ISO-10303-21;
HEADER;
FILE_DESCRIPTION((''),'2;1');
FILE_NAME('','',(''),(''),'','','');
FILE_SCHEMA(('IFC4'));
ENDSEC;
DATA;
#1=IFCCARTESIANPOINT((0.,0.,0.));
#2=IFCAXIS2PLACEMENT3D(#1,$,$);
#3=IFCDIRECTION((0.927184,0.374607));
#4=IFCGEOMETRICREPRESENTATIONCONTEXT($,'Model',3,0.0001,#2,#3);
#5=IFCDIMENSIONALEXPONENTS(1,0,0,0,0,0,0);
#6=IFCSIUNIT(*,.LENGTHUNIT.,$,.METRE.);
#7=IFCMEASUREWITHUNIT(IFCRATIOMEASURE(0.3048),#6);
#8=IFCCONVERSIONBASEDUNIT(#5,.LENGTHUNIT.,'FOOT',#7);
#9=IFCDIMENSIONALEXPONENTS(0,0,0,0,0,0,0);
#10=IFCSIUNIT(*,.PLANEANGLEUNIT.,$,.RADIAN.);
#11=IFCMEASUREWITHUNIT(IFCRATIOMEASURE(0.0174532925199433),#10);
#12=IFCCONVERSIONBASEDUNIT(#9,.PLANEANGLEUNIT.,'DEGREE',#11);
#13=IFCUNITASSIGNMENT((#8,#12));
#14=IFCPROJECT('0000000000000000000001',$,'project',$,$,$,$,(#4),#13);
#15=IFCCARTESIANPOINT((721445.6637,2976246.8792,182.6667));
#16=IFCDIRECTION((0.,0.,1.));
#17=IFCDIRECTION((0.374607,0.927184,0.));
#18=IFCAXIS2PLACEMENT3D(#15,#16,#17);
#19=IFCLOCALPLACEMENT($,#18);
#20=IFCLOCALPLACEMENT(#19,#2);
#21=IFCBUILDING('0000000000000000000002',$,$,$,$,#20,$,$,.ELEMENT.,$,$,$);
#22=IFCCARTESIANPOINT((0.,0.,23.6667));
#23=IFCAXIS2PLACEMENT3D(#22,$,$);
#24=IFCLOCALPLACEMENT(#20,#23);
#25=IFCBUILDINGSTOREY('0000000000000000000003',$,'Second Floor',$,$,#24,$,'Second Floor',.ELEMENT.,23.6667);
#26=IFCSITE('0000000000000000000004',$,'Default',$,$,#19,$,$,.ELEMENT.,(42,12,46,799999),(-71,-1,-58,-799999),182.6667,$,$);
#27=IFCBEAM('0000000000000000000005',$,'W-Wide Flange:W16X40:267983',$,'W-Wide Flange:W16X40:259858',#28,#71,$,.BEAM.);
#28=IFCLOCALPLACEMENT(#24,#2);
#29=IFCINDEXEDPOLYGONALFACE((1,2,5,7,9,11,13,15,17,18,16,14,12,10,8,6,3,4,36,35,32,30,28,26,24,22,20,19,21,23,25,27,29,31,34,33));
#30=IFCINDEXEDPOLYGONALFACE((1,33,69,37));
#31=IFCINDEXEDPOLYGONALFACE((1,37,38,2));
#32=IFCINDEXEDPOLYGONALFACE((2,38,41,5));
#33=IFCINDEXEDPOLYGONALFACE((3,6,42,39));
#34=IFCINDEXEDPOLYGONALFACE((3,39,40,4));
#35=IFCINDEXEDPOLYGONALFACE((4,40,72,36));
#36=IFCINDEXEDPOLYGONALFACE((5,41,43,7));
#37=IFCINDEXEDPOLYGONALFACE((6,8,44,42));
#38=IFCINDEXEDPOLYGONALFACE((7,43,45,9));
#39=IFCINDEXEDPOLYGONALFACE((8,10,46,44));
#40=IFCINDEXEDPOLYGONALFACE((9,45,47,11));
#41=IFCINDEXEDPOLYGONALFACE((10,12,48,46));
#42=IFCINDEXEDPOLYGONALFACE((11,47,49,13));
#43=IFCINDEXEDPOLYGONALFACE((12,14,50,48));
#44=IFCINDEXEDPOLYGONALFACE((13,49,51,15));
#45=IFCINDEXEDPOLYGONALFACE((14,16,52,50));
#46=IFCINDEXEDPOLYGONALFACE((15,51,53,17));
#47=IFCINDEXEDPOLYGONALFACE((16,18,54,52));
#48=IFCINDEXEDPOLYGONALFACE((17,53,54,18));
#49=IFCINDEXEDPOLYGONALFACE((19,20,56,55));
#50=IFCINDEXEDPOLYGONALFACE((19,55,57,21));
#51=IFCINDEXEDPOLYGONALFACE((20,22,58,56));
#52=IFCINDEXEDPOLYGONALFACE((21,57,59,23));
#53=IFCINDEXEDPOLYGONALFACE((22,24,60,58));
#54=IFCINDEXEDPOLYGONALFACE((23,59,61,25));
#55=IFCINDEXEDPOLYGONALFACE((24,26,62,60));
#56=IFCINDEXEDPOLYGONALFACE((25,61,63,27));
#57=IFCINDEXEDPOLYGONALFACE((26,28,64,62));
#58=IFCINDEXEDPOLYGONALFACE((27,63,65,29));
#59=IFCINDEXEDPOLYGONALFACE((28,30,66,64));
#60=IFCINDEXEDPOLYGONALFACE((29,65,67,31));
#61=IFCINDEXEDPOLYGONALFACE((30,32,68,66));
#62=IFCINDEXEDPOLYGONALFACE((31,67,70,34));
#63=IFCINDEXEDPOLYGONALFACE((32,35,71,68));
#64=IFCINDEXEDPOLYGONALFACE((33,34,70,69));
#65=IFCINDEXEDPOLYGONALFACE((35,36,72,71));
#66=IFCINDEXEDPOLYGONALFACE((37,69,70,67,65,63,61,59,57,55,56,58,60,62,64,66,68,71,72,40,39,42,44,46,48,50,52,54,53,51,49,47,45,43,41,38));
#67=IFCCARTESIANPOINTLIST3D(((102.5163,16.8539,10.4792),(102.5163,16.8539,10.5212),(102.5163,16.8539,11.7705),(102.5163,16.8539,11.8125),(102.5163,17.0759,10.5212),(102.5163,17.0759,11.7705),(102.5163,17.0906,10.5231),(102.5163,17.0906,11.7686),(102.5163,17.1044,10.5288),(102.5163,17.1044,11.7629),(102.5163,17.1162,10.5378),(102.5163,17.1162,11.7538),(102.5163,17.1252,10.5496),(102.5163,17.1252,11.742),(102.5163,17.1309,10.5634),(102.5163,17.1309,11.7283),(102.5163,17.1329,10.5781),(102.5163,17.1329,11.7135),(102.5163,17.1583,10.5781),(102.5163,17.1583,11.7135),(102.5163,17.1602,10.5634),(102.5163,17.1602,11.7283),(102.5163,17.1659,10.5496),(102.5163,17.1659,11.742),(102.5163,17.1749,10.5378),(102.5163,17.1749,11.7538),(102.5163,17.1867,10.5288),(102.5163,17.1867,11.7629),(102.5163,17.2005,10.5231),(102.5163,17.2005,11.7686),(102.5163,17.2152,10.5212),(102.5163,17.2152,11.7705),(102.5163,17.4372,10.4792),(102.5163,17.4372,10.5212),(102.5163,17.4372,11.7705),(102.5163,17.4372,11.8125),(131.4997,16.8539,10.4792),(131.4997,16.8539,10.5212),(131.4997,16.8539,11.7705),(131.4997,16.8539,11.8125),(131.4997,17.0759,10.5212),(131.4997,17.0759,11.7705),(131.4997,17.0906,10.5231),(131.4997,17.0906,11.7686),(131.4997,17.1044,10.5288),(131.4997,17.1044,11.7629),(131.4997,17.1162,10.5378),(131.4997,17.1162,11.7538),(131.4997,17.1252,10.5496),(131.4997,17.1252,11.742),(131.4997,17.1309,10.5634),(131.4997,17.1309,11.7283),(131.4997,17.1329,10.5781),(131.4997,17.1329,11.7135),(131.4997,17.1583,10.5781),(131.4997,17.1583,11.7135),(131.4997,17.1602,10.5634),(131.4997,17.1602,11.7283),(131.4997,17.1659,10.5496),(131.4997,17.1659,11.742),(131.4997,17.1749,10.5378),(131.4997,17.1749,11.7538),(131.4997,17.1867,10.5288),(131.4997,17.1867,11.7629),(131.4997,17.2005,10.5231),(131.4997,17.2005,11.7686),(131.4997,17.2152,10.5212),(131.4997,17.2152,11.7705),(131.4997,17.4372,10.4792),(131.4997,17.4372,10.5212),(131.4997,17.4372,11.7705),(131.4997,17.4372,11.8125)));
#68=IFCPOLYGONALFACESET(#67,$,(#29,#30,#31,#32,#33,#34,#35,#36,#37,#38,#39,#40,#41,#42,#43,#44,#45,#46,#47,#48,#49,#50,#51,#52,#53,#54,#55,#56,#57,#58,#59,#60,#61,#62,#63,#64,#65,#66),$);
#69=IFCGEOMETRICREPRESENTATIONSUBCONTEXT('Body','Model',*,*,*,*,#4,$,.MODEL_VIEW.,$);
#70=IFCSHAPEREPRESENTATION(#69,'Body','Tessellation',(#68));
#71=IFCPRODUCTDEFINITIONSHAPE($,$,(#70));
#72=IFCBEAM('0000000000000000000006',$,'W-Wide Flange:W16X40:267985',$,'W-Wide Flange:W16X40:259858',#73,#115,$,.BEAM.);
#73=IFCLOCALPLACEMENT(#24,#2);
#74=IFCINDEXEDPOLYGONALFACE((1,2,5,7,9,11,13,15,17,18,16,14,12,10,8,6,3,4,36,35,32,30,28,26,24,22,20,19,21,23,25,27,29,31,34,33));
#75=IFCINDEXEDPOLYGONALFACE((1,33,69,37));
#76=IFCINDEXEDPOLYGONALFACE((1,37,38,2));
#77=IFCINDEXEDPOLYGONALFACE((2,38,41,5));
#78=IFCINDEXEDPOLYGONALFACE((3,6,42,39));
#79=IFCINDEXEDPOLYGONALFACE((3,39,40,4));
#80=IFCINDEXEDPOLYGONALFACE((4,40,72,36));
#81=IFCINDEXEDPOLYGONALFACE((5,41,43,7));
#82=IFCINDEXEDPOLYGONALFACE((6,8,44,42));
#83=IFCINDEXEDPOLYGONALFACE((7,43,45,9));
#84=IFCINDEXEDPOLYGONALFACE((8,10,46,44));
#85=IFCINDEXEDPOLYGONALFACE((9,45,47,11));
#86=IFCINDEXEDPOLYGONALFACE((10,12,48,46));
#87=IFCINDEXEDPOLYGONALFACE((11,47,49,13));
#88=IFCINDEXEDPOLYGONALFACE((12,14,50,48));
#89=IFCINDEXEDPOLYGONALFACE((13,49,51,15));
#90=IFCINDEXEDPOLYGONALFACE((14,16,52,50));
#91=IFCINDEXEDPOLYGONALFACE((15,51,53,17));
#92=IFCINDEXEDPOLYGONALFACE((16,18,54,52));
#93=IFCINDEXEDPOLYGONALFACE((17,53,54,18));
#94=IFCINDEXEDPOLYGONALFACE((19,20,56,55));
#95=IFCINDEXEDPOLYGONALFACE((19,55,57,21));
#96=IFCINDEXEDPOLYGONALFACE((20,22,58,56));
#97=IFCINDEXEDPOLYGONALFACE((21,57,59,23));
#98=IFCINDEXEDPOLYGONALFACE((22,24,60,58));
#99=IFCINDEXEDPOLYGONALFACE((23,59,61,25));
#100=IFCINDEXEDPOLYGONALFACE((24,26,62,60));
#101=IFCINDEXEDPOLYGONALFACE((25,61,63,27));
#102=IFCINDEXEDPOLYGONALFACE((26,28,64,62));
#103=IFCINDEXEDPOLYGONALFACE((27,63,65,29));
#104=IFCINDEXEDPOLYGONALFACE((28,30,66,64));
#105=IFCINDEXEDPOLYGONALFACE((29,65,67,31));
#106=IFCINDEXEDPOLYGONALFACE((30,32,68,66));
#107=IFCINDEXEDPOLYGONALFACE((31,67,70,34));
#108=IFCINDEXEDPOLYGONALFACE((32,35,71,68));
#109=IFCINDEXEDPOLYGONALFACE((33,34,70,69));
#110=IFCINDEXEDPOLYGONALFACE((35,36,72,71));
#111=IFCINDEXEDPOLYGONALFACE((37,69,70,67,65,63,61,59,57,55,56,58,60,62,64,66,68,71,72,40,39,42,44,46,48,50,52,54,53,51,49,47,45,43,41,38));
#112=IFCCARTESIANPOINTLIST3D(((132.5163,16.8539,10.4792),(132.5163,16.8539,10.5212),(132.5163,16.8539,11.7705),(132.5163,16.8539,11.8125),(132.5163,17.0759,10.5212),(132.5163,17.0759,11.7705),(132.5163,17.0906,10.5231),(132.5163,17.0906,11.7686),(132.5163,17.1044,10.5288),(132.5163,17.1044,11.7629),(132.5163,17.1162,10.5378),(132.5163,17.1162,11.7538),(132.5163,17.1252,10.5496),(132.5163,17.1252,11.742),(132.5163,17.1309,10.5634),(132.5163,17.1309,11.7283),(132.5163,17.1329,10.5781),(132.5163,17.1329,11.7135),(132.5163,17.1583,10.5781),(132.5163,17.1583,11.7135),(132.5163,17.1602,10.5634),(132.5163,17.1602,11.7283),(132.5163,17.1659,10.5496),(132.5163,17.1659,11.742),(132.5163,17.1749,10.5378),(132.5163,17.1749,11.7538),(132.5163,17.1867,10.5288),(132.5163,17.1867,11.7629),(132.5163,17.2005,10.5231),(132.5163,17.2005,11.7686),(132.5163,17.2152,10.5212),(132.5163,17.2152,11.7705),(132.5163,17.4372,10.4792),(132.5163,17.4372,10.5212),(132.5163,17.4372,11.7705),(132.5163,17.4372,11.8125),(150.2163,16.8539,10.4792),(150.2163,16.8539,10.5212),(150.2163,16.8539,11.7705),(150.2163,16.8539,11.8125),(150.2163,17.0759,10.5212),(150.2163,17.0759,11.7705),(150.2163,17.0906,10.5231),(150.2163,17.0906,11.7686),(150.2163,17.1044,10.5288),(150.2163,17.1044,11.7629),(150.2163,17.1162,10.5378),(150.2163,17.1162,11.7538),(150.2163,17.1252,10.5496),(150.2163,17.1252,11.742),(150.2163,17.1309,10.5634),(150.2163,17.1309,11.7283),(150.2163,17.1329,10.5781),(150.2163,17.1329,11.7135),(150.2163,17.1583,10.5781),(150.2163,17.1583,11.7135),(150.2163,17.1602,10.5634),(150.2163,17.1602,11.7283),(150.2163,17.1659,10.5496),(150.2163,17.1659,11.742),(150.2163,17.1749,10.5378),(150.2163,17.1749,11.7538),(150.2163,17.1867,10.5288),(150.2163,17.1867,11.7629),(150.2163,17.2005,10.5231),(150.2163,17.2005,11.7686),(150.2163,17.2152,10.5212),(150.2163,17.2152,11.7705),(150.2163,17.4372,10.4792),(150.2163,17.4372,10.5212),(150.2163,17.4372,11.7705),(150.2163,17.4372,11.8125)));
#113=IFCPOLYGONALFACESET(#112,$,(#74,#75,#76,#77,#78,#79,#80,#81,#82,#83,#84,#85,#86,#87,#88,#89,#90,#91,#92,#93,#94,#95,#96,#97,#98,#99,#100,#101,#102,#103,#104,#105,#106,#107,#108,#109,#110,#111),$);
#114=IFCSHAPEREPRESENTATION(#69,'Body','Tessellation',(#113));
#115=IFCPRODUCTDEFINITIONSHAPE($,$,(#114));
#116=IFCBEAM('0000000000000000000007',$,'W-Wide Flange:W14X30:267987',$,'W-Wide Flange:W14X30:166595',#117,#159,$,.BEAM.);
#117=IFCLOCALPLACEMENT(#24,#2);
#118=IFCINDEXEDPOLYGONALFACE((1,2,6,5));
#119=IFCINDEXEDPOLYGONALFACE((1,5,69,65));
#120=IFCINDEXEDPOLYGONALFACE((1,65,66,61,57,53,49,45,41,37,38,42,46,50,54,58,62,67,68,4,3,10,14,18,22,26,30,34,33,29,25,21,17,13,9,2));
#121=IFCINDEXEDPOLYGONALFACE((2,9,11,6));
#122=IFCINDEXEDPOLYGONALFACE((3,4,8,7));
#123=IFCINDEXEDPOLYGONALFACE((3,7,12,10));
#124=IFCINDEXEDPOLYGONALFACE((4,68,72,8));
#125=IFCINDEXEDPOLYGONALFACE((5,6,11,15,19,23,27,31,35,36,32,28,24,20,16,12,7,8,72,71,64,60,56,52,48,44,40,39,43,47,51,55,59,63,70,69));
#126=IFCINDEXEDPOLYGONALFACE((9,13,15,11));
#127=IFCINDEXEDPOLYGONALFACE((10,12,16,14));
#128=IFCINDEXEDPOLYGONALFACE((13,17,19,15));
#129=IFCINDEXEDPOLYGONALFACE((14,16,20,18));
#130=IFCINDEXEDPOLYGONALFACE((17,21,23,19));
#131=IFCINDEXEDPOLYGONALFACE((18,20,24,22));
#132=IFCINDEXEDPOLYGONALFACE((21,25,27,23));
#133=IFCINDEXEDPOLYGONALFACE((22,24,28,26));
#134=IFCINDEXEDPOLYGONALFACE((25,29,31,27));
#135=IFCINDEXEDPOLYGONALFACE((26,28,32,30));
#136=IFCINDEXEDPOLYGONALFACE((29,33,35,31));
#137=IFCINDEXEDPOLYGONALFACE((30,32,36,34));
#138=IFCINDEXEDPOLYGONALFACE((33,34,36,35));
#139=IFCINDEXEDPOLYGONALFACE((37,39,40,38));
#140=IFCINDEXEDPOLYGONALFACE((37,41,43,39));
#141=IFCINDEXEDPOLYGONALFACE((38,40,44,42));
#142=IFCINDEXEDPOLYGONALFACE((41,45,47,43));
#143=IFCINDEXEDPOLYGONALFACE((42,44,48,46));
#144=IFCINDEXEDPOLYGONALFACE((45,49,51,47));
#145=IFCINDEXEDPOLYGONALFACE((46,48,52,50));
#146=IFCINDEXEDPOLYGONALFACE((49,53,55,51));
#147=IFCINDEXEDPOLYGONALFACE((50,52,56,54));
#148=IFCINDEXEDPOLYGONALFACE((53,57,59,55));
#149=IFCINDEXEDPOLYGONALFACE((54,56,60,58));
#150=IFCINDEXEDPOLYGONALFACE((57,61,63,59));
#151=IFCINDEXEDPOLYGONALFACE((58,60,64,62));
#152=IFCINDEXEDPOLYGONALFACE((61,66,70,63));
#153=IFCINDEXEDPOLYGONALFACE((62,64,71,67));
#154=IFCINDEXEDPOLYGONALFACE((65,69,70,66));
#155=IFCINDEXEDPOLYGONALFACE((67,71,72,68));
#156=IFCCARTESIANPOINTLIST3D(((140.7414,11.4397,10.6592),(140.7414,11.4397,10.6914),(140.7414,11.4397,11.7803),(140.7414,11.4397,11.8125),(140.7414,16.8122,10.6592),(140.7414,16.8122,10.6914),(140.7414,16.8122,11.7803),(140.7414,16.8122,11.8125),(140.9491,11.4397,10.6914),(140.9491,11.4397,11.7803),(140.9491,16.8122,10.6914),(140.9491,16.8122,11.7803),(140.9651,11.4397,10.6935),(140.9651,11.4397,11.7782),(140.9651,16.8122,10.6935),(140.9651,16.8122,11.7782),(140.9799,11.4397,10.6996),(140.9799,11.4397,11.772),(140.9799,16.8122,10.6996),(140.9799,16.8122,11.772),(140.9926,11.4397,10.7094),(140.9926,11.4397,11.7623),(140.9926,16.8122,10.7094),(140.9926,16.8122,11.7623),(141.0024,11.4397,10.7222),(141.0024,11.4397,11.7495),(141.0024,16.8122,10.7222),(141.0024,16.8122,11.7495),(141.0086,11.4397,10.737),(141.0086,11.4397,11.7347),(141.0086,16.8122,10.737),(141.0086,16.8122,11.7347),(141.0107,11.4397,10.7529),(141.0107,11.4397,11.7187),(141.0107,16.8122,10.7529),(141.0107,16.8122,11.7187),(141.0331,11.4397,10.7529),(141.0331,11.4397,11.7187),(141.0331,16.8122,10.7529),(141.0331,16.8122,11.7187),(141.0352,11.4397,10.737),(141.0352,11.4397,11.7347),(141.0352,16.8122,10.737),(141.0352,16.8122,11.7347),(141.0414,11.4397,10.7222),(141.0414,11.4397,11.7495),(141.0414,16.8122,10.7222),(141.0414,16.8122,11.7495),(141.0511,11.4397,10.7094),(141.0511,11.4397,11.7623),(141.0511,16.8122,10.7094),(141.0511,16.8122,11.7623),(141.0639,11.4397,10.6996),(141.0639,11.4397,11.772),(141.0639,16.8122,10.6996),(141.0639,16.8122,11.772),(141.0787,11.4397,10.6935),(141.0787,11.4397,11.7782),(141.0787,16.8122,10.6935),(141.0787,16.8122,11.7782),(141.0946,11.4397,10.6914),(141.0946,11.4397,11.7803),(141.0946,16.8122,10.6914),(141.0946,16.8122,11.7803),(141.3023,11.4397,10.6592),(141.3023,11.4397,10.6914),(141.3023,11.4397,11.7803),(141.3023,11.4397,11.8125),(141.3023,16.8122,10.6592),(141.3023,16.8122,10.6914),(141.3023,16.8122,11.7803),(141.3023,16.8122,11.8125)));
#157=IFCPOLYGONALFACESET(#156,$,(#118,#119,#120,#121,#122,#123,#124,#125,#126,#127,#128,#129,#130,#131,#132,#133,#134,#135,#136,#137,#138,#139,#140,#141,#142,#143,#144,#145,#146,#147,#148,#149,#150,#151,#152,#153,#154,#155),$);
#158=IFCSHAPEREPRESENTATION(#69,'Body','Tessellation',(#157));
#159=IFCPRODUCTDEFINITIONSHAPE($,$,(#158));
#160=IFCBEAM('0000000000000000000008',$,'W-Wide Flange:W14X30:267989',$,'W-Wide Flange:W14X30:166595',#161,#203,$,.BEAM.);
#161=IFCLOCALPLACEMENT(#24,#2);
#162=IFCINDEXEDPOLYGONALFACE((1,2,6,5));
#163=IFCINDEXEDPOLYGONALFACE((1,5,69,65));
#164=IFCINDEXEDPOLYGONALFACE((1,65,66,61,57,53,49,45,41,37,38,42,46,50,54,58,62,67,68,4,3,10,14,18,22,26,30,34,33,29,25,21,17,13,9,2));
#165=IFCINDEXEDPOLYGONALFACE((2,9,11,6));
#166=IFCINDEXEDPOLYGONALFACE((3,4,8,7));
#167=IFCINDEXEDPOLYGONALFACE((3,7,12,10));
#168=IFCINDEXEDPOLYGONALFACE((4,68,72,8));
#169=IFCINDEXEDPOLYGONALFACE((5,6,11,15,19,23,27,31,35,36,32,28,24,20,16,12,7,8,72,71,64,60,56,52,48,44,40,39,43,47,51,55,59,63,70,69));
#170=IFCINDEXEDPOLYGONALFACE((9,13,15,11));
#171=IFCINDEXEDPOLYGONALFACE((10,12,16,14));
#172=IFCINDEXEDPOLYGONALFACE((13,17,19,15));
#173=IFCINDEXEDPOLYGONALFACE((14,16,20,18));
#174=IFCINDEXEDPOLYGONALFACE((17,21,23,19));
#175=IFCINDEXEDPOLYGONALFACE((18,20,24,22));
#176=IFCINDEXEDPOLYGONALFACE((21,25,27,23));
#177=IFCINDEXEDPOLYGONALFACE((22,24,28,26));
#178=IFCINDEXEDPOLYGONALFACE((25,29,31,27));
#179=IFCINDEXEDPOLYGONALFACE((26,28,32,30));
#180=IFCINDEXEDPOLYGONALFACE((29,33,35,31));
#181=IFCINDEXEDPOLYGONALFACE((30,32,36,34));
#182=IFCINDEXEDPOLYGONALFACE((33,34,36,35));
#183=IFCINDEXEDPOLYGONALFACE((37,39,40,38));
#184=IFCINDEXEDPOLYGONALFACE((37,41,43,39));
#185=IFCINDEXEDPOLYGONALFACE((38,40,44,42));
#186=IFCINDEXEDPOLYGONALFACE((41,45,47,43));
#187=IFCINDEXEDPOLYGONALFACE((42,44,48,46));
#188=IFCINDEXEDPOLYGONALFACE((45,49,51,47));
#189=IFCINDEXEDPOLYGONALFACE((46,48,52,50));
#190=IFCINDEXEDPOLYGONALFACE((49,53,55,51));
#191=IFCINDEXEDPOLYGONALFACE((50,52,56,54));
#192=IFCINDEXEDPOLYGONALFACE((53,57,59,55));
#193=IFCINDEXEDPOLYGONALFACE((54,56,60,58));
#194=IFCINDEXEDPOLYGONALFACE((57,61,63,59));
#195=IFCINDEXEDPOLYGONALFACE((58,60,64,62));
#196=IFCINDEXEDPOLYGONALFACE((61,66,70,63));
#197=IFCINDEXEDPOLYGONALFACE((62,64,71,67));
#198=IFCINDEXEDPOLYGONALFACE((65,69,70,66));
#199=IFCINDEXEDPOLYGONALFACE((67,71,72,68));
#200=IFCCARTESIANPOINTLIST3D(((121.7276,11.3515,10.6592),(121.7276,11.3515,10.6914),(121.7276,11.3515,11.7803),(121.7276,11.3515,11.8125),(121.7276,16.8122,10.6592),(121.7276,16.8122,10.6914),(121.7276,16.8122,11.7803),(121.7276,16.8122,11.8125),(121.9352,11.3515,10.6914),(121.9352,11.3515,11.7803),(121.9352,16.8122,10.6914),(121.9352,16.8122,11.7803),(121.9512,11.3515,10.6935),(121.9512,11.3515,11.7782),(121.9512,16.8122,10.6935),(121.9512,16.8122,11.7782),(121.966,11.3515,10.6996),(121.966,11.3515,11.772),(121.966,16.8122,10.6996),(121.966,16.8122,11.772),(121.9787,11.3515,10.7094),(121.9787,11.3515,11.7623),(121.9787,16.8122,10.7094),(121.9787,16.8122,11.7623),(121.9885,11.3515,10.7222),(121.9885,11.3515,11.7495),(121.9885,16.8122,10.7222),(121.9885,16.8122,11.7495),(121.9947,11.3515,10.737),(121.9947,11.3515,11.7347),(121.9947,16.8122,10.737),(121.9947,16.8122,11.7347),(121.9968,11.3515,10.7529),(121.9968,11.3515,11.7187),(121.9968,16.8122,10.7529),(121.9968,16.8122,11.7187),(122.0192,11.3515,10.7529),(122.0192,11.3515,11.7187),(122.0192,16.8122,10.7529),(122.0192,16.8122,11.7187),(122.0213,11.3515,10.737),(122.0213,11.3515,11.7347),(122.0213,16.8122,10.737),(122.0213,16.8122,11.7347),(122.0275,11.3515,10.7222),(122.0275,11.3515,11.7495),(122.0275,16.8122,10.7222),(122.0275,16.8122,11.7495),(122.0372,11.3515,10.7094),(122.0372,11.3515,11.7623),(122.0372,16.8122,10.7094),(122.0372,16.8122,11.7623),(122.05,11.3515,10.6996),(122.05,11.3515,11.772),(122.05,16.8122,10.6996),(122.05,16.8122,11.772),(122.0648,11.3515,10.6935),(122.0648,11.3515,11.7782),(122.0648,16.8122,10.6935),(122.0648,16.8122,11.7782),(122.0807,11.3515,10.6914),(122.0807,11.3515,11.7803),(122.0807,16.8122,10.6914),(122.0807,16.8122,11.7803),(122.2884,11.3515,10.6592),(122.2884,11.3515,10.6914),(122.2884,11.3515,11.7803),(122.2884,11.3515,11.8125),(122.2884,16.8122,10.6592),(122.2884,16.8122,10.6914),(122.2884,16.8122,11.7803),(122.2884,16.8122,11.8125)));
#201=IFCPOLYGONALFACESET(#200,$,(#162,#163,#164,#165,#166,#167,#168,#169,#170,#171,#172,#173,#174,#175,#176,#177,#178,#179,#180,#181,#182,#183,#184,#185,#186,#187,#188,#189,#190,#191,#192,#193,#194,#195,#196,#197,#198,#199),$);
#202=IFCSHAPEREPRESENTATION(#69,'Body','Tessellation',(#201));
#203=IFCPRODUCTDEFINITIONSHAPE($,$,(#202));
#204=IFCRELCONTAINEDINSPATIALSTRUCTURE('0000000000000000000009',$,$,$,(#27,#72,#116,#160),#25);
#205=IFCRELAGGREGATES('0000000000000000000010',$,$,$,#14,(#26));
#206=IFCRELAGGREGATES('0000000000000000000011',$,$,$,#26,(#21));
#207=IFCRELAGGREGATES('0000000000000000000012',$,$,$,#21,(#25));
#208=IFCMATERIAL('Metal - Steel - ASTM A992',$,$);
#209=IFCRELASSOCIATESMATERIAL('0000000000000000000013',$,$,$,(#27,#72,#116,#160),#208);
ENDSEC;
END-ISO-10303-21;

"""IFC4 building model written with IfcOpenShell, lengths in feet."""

from ifc_helpers import new_model, entity, si_unit, converted_unit, direction, frame, frame_2d, origin, place, context, subcontext, project, spatial, i_section, extrude, material, element, save


model = new_model("IFC4")

# Units and contexts
model_context = context("Model", 3, precision=0.0001, world=origin(), true_north=direction((0.927184, 0.374607)))
body_context = subcontext(model_context, "Body", "Model", "MODEL_VIEW")
ifc_project = project(units=[converted_unit("LENGTHUNIT", "FOOT", entity("IfcRatioMeasure", 0.3048), si_unit("LENGTHUNIT", "METRE"), dimensions=[1, 0, 0, 0, 0, 0, 0]), converted_unit("PLANEANGLEUNIT", "DEGREE", entity("IfcRatioMeasure", 0.0174532925199433), si_unit("PLANEANGLEUNIT", "RADIAN"), dimensions=[0, 0, 0, 0, 0, 0, 0])], contexts=[model_context])

# Site, building, storey
site_placement = place(None, frame((721445.6637, 2976246.8792, 182.6667), z_axis=(0.0, 0.0, 1.0), x_axis=(0.374607, 0.927184, 0.0)))
site = spatial("IfcSite", under=ifc_project, at=site_placement, Name="Default", CompositionType="ELEMENT", RefLatitude=(42, 12, 46, 799999), RefLongitude=(-71, -1, -58, -799999), RefElevation=182.6667)
building_placement = place(site_placement, origin())
building = spatial("IfcBuilding", under=site, at=building_placement, CompositionType="ELEMENT")
storey_placement = place(building_placement, frame((0.0, 0.0, 23.6667)))
storey = spatial("IfcBuildingStorey", under=building, at=storey_placement, Name="Second Floor", LongName="Second Floor", CompositionType="ELEMENT", Elevation=23.6667)

# Shared definitions
ifc_material_1 = material(Name="Metal - Steel - ASTM A992")

# Beams
beam_1_placement = place(storey_placement, frame((102.008, 17.1456, 11.8125)))
element("IfcBeam", 1, at=beam_1_placement, inside=storey, material=ifc_material_1, Name="W-Wide Flange:W16X40:267983", ObjectType="W-Wide Flange:W16X40:259858", PredefinedType="BEAM", context=body_context, shape_type="SweptSolid", body=[
    extrude(i_section(OverallWidth=0.5833, OverallDepth=1.3333, WebThickness=0.0254, FlangeThickness=0.042, FilletRadius=0.057, at=frame_2d((0.0, 0.0), x_axis=(0.0, 1.0))), frame((0.5083, 0.0, -0.6667), z_axis=(1.0, 0.0, 0.0), x_axis=(0.0, 0.0, -1.0)), (0.0, 0.0, 1.0), 28.9834),
])
beam_2_placement = place(storey_placement, frame((132.008, 17.1456, 11.8125)))
element("IfcBeam", 2, at=beam_2_placement, inside=storey, material=ifc_material_1, Name="W-Wide Flange:W16X40:267985", ObjectType="W-Wide Flange:W16X40:259858", PredefinedType="BEAM", context=body_context, shape_type="SweptSolid", body=[
    extrude(i_section(OverallWidth=0.5833, OverallDepth=1.3333, WebThickness=0.0254, FlangeThickness=0.042, FilletRadius=0.057, at=frame_2d((0.0, 0.0), x_axis=(0.0, 1.0))), frame((0.5083, 0.0, -0.6667), z_axis=(1.0, 0.0, 0.0), x_axis=(0.0, 0.0, -1.0)), (0.0, 0.0, 1.0), 17.7),
])
beam_3_placement = place(storey_placement, frame((141.0219, 11.1456, 11.8125), z_axis=(0.0, 0.0, 1.0), x_axis=(0.0, 1.0, 0.0)))
element("IfcBeam", 3, at=beam_3_placement, inside=storey, material=ifc_material_1, Name="W-Wide Flange:W14X30:267987", ObjectType="W-Wide Flange:W14X30:166595", PredefinedType="BEAM", context=body_context, shape_type="SweptSolid", body=[
    extrude(i_section(OverallWidth=0.5609, OverallDepth=1.1533, WebThickness=0.0225, FlangeThickness=0.0322, FilletRadius=0.0615, at=frame_2d((0.0, 0.0), x_axis=(0.0, 1.0))), frame((0.2941, 0.0, -0.5767), z_axis=(1.0, 0.0, 0.0), x_axis=(0.0, 0.0, -1.0)), (0.0, 0.0, 1.0), 5.3726),
])
beam_4_placement = place(storey_placement, frame((122.008, 11.1456, 11.8125), z_axis=(0.0, 0.0, 1.0), x_axis=(0.0, 1.0, 0.0)))
element("IfcBeam", 4, at=beam_4_placement, inside=storey, material=ifc_material_1, Name="W-Wide Flange:W14X30:267989", ObjectType="W-Wide Flange:W14X30:166595", PredefinedType="BEAM", context=body_context, shape_type="SweptSolid", body=[
    extrude(i_section(OverallWidth=0.5609, OverallDepth=1.1533, WebThickness=0.0225, FlangeThickness=0.0322, FilletRadius=0.0615, at=frame_2d((0.0, 0.0), x_axis=(0.0, 1.0))), frame((0.2059, 0.0, -0.5767), z_axis=(1.0, 0.0, 0.0), x_axis=(0.0, 0.0, -1.0)), (0.0, 0.0, 1.0), 5.4608),
])

save(model, "model.ifc")
